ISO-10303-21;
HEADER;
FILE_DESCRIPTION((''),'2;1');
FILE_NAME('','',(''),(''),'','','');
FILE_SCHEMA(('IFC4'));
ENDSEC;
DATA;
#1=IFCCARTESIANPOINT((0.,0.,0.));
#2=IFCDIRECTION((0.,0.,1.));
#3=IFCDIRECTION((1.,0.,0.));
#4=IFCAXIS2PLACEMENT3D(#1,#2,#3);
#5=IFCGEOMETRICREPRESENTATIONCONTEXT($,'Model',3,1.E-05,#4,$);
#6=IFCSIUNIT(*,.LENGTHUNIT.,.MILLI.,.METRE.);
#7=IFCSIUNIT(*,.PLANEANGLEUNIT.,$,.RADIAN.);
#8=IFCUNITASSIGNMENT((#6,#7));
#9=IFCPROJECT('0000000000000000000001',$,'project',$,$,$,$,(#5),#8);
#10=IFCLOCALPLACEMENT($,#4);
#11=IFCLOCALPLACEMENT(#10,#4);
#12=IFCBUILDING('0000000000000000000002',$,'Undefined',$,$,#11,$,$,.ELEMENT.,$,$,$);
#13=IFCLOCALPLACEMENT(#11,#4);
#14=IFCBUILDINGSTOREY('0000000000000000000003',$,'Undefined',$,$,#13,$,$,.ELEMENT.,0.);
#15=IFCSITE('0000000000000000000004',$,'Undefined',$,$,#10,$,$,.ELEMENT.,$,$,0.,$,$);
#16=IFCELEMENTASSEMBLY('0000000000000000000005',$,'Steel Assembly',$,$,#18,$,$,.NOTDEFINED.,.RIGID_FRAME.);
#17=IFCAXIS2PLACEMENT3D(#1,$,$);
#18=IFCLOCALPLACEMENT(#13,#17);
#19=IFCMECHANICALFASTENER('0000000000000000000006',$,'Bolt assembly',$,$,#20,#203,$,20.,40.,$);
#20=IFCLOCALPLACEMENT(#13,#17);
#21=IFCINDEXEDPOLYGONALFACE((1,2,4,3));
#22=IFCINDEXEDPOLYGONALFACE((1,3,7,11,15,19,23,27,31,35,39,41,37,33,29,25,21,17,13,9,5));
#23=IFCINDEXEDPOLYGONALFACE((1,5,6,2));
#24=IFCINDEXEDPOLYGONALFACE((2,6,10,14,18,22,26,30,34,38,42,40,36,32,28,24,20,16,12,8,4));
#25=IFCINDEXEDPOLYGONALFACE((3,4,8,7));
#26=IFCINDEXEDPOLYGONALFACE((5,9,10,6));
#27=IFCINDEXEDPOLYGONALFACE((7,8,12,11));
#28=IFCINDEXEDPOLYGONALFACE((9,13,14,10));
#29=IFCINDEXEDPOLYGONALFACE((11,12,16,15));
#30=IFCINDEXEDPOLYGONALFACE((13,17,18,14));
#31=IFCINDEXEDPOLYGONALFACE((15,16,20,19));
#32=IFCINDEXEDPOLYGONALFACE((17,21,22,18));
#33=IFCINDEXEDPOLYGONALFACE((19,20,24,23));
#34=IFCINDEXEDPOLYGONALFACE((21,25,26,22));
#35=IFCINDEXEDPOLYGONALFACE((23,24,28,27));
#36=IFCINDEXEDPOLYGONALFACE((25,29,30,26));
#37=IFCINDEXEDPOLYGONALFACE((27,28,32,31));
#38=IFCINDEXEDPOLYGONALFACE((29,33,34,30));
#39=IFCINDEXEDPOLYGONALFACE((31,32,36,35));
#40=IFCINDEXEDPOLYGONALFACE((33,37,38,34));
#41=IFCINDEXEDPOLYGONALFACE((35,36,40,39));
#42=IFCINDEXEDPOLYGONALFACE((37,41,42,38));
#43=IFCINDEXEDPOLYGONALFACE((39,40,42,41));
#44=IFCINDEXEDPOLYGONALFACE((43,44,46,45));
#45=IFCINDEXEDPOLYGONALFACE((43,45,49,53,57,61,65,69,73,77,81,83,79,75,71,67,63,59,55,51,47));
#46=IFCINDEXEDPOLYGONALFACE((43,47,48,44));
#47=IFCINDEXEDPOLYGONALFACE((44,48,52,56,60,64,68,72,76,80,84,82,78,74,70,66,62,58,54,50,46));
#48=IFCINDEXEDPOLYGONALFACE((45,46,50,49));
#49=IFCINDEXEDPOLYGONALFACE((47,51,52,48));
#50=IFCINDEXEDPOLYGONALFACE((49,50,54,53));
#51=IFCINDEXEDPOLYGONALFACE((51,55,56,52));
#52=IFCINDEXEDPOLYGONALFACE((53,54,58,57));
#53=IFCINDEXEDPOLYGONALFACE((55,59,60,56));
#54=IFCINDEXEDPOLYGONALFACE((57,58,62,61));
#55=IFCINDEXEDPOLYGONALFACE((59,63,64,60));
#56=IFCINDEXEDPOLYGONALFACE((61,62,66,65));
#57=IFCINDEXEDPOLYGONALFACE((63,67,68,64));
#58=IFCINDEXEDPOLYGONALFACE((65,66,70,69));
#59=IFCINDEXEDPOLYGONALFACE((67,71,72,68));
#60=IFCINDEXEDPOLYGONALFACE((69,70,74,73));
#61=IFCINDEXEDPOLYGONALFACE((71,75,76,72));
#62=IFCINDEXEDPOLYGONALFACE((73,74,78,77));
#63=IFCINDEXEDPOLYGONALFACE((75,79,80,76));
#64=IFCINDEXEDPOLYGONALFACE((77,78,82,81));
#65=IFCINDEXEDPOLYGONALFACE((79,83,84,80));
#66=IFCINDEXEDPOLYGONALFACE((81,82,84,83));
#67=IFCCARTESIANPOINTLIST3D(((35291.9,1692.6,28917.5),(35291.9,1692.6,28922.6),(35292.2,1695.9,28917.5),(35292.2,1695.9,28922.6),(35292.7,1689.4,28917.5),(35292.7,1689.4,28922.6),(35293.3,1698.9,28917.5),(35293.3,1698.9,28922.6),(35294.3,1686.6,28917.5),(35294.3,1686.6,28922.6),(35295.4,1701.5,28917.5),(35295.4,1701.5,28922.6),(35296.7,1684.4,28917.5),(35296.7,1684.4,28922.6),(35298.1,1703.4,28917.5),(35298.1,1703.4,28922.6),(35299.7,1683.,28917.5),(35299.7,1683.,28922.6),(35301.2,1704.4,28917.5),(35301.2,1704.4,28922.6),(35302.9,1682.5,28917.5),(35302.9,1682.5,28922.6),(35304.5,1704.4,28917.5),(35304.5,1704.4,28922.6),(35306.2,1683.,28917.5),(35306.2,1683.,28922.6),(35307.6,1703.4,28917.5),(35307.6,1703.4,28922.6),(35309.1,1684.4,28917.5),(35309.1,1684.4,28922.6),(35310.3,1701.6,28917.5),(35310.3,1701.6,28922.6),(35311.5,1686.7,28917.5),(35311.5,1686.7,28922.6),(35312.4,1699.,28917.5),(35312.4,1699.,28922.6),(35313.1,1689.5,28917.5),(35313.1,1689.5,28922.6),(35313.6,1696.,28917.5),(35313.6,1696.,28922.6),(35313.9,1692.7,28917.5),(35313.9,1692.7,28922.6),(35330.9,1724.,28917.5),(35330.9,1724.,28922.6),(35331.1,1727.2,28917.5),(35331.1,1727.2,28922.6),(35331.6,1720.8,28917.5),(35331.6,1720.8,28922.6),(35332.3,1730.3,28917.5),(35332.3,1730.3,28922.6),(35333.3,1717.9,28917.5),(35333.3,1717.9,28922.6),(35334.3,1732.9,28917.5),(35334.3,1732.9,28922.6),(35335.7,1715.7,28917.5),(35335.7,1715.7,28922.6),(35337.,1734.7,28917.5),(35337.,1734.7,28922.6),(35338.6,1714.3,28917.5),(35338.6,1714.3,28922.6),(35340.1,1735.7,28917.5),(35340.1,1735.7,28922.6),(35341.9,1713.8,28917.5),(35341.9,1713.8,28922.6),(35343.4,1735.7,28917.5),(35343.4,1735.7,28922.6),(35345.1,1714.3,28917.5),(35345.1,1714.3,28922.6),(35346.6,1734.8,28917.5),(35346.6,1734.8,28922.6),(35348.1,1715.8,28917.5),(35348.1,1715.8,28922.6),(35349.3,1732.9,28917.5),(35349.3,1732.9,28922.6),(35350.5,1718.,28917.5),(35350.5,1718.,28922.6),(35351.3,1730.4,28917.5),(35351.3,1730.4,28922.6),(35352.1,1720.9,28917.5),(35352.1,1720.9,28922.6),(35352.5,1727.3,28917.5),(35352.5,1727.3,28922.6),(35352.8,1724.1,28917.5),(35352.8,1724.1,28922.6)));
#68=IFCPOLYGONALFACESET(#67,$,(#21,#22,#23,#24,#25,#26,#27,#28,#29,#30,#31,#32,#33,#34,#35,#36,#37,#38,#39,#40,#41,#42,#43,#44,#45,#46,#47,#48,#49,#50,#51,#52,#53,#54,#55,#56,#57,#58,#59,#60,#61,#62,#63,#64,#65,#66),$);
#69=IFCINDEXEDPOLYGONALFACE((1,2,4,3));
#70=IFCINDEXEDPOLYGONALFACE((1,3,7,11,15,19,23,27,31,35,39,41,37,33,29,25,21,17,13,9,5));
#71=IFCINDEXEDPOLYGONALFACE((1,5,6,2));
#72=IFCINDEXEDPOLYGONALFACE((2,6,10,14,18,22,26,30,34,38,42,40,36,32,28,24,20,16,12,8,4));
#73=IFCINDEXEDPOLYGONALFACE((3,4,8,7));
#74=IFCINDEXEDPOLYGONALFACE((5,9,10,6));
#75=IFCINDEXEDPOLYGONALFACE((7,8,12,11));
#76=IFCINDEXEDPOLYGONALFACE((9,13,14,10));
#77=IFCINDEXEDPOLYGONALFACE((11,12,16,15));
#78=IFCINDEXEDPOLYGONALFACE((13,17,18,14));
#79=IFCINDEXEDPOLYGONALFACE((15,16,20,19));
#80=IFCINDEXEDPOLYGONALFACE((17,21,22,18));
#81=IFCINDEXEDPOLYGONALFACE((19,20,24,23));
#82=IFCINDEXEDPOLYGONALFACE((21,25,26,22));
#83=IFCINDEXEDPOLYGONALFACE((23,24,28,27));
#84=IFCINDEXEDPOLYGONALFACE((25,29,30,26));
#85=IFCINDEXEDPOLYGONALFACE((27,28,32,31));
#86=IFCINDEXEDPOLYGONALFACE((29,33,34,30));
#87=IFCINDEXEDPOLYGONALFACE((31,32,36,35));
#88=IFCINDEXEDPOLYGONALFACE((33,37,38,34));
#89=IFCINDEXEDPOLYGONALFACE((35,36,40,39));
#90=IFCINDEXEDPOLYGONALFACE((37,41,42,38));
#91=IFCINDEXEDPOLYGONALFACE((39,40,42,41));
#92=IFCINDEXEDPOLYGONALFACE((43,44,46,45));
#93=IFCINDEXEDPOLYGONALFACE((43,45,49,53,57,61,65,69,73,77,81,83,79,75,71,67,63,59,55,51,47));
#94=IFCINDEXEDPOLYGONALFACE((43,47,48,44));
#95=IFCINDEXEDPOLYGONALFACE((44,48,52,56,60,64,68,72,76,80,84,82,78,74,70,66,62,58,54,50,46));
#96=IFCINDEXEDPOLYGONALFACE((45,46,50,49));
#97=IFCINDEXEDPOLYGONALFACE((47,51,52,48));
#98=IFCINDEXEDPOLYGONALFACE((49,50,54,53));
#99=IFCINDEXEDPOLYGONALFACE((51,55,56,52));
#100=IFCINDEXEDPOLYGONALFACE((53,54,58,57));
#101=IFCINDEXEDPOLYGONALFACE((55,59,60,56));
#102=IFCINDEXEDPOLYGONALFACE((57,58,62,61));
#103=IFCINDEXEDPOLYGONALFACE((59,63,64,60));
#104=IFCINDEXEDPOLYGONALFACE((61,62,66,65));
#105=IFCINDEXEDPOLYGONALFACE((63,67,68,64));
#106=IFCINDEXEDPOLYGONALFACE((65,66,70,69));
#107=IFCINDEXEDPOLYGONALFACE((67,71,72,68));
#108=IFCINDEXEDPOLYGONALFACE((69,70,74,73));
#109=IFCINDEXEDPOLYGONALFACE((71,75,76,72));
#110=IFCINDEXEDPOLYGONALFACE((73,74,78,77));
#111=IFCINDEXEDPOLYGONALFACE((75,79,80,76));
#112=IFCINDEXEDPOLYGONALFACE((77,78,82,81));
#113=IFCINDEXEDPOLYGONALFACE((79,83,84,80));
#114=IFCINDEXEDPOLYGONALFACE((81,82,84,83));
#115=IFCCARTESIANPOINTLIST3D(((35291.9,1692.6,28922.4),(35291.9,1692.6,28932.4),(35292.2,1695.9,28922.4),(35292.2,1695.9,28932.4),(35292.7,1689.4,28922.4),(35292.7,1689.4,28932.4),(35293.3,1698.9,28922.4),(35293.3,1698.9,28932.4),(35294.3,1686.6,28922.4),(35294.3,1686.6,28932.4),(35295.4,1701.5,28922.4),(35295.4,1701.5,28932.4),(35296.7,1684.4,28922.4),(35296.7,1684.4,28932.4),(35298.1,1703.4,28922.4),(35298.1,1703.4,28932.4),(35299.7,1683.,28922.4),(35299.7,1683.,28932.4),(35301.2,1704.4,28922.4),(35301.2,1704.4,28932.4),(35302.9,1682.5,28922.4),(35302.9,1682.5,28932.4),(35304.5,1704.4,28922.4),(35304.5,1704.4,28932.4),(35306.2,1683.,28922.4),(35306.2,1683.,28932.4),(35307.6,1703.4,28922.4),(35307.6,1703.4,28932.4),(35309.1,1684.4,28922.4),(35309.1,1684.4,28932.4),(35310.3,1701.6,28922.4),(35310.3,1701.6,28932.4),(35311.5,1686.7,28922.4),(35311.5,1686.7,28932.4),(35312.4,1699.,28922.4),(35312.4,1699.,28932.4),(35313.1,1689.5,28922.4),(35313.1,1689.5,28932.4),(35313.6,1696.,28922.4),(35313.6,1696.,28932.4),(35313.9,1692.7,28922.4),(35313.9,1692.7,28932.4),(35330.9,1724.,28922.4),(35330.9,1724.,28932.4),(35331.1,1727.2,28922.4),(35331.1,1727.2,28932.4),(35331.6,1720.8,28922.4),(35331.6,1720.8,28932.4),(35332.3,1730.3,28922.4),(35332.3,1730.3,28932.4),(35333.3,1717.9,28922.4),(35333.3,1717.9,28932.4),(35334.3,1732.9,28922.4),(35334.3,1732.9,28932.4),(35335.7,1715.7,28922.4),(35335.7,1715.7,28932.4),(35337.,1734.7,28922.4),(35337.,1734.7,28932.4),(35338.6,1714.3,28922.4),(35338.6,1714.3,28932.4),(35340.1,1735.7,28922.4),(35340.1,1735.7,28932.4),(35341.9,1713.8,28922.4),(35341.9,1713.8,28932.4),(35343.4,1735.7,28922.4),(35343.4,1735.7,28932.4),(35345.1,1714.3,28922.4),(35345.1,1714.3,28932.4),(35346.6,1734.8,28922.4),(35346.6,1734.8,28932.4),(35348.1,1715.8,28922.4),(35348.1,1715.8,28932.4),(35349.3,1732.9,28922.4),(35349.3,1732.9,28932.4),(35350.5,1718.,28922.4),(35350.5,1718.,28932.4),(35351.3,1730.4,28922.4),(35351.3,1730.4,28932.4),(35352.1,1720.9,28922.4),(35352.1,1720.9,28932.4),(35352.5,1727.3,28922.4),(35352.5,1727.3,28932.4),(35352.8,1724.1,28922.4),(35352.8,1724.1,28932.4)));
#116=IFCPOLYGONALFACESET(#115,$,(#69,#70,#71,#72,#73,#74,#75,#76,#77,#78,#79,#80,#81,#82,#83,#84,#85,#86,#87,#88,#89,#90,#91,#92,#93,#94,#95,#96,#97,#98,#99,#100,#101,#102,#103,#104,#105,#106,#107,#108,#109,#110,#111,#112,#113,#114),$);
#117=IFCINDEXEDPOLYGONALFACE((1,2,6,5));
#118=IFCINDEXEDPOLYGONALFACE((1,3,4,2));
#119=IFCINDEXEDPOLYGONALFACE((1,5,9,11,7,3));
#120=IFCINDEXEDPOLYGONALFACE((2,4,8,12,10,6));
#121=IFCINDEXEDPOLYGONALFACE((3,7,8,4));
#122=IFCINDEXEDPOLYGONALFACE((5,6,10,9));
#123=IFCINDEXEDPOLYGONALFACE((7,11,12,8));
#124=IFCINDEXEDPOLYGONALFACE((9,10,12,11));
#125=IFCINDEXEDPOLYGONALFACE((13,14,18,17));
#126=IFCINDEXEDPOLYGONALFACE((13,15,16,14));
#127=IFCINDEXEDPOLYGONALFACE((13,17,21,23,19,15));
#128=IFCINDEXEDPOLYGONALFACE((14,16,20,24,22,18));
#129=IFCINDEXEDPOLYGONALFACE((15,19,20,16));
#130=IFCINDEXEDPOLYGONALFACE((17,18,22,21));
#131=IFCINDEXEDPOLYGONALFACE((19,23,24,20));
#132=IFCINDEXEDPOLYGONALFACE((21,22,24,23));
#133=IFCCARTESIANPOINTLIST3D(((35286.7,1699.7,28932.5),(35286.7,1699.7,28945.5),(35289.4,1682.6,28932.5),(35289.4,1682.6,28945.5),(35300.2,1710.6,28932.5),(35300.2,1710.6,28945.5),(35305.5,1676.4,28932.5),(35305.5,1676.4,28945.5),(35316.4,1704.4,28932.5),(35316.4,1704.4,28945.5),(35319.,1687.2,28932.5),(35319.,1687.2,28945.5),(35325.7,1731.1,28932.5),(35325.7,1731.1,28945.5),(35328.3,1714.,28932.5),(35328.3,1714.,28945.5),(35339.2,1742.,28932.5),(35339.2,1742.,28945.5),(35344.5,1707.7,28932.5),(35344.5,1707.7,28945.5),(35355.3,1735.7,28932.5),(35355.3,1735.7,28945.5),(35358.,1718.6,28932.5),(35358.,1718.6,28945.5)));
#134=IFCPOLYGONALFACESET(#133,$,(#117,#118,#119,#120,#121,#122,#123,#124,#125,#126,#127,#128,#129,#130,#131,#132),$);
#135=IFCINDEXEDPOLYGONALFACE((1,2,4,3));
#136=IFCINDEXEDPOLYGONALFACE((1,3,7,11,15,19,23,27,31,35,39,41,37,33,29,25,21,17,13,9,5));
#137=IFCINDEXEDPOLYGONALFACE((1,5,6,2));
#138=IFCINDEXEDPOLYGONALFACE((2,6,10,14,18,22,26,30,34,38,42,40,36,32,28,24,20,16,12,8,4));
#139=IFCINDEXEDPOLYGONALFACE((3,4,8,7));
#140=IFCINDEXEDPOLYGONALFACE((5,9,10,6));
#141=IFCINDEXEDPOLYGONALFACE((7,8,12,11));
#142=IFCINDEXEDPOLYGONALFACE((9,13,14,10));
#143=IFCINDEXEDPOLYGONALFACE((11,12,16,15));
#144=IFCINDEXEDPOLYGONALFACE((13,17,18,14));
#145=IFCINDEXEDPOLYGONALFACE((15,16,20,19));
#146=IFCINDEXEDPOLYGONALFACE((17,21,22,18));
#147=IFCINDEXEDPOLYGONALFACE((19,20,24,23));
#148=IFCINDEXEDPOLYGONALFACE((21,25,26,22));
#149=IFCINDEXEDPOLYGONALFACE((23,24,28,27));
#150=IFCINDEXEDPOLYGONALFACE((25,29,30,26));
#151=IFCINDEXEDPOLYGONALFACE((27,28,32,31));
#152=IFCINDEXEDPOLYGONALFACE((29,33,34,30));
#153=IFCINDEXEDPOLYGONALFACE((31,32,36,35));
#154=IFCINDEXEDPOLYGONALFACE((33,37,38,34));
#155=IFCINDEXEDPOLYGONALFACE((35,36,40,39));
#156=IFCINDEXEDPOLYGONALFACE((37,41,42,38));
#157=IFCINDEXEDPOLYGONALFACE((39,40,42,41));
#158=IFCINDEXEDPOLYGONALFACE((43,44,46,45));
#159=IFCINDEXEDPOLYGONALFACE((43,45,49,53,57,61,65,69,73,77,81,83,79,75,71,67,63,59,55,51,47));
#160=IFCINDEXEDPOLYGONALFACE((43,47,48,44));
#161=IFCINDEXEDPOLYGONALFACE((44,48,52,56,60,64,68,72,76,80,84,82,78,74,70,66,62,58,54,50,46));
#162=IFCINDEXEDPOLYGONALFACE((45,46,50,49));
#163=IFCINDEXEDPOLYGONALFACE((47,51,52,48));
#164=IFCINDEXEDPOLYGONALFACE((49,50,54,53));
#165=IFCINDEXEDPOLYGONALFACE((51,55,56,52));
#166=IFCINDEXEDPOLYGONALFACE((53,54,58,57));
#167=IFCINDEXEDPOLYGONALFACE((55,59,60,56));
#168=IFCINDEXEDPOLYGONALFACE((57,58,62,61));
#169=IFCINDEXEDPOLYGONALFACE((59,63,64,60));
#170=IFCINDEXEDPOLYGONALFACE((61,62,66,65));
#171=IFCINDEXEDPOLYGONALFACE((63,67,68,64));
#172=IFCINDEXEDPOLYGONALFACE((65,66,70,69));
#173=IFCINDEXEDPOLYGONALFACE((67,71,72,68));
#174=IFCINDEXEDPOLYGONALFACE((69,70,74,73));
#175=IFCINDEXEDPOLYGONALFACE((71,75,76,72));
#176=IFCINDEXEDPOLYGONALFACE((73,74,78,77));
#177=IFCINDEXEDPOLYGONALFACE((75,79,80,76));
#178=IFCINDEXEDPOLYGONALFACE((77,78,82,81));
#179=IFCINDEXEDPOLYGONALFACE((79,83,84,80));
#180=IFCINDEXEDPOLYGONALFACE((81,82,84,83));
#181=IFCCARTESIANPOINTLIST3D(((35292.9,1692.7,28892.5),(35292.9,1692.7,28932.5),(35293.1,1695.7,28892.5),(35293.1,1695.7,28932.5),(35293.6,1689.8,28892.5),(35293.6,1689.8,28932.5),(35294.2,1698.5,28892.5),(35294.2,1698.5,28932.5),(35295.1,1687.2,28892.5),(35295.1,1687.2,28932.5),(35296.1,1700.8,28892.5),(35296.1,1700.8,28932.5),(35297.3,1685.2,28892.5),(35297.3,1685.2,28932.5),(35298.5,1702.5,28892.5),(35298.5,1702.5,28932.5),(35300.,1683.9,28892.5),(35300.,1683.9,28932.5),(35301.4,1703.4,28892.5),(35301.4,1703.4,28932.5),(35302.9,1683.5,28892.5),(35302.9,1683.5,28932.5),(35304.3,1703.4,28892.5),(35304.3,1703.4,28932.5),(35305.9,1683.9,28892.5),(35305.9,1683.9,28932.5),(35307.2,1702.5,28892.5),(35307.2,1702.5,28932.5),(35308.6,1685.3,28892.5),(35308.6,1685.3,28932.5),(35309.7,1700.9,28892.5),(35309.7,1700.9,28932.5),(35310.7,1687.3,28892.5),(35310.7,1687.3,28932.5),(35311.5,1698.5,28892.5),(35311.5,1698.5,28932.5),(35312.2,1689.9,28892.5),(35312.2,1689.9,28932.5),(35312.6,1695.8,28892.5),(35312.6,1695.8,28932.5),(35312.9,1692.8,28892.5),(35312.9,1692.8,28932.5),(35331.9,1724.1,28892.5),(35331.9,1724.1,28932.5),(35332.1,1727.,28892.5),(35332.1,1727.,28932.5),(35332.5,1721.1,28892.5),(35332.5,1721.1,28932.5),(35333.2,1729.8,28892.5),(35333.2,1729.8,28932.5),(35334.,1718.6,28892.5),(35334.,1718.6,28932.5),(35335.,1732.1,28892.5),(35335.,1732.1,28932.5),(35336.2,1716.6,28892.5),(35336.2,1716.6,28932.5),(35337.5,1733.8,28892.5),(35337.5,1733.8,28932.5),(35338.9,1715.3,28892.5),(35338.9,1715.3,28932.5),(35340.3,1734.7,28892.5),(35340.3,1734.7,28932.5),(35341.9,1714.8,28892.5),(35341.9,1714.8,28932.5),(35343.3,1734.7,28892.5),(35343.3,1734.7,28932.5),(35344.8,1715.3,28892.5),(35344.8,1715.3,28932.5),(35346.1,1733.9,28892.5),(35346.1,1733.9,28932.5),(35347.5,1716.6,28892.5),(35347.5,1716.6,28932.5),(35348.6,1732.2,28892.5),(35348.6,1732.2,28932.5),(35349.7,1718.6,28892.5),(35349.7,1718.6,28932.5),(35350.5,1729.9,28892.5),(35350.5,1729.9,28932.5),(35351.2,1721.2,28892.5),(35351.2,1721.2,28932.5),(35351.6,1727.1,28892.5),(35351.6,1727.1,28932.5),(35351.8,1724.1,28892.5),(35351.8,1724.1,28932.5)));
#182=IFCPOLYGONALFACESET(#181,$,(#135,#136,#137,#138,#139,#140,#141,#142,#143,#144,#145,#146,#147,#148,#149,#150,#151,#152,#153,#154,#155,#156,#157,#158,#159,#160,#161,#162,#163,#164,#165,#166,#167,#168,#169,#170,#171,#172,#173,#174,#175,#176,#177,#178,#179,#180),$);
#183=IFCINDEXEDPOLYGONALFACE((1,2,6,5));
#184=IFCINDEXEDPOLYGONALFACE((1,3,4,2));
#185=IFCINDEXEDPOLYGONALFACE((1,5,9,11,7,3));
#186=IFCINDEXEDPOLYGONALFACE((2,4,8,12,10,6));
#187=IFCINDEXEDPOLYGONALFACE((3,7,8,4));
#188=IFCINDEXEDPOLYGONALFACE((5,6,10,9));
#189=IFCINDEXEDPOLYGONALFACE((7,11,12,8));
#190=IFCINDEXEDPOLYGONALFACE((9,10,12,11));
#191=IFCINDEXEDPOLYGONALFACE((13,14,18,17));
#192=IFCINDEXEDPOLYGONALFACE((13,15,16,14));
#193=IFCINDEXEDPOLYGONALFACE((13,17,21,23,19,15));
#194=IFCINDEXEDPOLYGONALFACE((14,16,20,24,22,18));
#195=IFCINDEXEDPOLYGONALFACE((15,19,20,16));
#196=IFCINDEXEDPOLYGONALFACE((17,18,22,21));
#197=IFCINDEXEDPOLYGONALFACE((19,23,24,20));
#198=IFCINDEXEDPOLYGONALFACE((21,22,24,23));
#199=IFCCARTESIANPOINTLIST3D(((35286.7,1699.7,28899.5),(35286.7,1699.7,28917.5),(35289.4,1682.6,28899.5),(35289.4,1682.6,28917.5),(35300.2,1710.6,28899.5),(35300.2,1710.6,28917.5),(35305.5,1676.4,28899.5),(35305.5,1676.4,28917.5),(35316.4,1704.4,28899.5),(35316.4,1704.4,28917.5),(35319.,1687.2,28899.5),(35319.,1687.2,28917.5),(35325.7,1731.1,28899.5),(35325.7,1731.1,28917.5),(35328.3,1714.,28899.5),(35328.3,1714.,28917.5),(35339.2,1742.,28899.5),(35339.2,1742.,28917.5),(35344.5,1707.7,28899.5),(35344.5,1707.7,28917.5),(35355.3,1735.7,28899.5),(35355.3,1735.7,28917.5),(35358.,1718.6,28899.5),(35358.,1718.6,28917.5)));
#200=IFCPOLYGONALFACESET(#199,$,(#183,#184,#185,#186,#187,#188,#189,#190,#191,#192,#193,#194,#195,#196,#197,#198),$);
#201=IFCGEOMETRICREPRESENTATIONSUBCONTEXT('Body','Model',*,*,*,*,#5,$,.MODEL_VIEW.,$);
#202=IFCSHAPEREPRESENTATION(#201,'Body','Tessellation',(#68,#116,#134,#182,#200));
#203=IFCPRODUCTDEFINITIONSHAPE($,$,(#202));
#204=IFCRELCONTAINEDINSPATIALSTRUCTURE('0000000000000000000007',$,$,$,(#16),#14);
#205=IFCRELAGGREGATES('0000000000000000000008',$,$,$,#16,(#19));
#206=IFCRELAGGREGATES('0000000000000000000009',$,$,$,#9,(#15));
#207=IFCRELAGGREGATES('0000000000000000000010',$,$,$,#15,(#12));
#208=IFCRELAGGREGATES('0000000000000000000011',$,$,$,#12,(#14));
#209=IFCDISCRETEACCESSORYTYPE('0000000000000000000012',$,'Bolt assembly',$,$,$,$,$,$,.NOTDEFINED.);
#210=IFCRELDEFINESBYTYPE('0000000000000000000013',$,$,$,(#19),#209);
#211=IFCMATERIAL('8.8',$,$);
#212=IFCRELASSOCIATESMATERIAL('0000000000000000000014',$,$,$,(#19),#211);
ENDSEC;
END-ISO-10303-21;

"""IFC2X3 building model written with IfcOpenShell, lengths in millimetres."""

from ifc_helpers import new_model, si_unit, frame, origin_with_axes, origin_2d_with_axis, place, context, subcontext, project, spatial, polyline, circle, outline, extrude, source, transform, mapped, material, type_object, element, aggregate, save


model = new_model("IFC2X3")

# Units and contexts
model_context = context("Model", 3, precision=1e-05, world=origin_with_axes())
body_context = subcontext(model_context, "Body", "Model", "MODEL_VIEW")
ifc_project = project(units=[si_unit("LENGTHUNIT", "METRE", prefix="MILLI"), si_unit("PLANEANGLEUNIT", "RADIAN")], contexts=[model_context])

# Site, building, storey
site_placement = place(None, origin_with_axes())
site = spatial("IfcSite", under=ifc_project, at=site_placement, Name="Undefined", CompositionType="ELEMENT", RefElevation=0.0)
building_placement = place(site_placement, origin_with_axes())
building = spatial("IfcBuilding", under=site, at=building_placement, Name="Undefined", CompositionType="ELEMENT")
storey_placement = place(building_placement, origin_with_axes())
storey = spatial("IfcBuildingStorey", under=building, at=storey_placement, Name="Undefined", CompositionType="ELEMENT", Elevation=0.0)

# Element assembly, mechanical fastener
discrete_accessory_type_1 = type_object("IfcDiscreteAccessoryType", Name="Bolt assembly")
assembly_1_placement = place(storey_placement, origin_with_axes())
assembly_1 = element("IfcElementAssembly", 1, at=assembly_1_placement, inside=storey, Name="Steel Assembly", AssemblyPlace="NOTDEFINED", PredefinedType="RIGID_FRAME")
ifc_material_1 = material(Name="8.8")
shared_shape_1 = source(origin_with_axes(), body_context, "Body", "SweptSolid", [
    extrude(circle(Radius=11.0, at=origin_2d_with_axis()), frame((0.0, -0.1, 0.0), z_axis=(0.0, 1.0, 0.0), x_axis=(1.0, 0.0, 0.0)), (0.0, 0.0, 1.0), 5.1),
    extrude(circle(Radius=11.0, at=origin_2d_with_axis()), frame((0.0, -9.9, 0.0), z_axis=(0.0, 1.0, 0.0), x_axis=(1.0, 0.0, 0.0)), (0.0, 0.0, 1.0), 10.0),
    extrude(outline(polyline([(17.3, 0.0), (8.7, 15.0), (-8.7, 15.0), (-17.3, 0.0), (-8.7, -15.0), (8.7, -15.0), (17.3, 0.0)])), frame((0.0, -23.0, 0.0), z_axis=(0.0, 1.0, 0.0), x_axis=(1.0, 0.0, 0.0)), (0.0, 0.0, 1.0), 13.0),
    extrude(circle(Radius=10.0, at=origin_2d_with_axis()), frame((0.0, -10.0, 0.0), z_axis=(0.0, 1.0, 0.0), x_axis=(1.0, 0.0, 0.0)), (0.0, 0.0, 1.0), 40.0),
    extrude(outline(polyline([(17.3, 0.0), (8.7, 15.0), (-8.7, 15.0), (-17.3, 0.0), (-8.7, -15.0), (8.7, -15.0), (17.3, 0.0)])), frame((0.0, 5.0, 0.0), z_axis=(0.0, 1.0, 0.0), x_axis=(1.0, 0.0, 0.0)), (0.0, 0.0, 1.0), 18.0),
])
mechanical_fastener_1_placement = place(assembly_1_placement, frame((35341.8, 1724.8, 28922.5), z_axis=(0.627081, -0.778954, 0.0), x_axis=(-0.778954, -0.627081, 0.0)))
mechanical_fastener_1 = element("IfcMechanicalFastener", 2, at=mechanical_fastener_1_placement, type_object=discrete_accessory_type_1, material=ifc_material_1, Name="Bolt assembly", NominalDiameter=20.0, NominalLength=40.0, context=body_context, shape_type="MappedRepresentation", body=[
    mapped(shared_shape_1, transform((0.0, 0.0, 0.0))),
    mapped(shared_shape_1, transform((50.0, 0.0, 0.0))),
])
aggregate(assembly_1, [mechanical_fastener_1])

save(model, "model.ifc")
